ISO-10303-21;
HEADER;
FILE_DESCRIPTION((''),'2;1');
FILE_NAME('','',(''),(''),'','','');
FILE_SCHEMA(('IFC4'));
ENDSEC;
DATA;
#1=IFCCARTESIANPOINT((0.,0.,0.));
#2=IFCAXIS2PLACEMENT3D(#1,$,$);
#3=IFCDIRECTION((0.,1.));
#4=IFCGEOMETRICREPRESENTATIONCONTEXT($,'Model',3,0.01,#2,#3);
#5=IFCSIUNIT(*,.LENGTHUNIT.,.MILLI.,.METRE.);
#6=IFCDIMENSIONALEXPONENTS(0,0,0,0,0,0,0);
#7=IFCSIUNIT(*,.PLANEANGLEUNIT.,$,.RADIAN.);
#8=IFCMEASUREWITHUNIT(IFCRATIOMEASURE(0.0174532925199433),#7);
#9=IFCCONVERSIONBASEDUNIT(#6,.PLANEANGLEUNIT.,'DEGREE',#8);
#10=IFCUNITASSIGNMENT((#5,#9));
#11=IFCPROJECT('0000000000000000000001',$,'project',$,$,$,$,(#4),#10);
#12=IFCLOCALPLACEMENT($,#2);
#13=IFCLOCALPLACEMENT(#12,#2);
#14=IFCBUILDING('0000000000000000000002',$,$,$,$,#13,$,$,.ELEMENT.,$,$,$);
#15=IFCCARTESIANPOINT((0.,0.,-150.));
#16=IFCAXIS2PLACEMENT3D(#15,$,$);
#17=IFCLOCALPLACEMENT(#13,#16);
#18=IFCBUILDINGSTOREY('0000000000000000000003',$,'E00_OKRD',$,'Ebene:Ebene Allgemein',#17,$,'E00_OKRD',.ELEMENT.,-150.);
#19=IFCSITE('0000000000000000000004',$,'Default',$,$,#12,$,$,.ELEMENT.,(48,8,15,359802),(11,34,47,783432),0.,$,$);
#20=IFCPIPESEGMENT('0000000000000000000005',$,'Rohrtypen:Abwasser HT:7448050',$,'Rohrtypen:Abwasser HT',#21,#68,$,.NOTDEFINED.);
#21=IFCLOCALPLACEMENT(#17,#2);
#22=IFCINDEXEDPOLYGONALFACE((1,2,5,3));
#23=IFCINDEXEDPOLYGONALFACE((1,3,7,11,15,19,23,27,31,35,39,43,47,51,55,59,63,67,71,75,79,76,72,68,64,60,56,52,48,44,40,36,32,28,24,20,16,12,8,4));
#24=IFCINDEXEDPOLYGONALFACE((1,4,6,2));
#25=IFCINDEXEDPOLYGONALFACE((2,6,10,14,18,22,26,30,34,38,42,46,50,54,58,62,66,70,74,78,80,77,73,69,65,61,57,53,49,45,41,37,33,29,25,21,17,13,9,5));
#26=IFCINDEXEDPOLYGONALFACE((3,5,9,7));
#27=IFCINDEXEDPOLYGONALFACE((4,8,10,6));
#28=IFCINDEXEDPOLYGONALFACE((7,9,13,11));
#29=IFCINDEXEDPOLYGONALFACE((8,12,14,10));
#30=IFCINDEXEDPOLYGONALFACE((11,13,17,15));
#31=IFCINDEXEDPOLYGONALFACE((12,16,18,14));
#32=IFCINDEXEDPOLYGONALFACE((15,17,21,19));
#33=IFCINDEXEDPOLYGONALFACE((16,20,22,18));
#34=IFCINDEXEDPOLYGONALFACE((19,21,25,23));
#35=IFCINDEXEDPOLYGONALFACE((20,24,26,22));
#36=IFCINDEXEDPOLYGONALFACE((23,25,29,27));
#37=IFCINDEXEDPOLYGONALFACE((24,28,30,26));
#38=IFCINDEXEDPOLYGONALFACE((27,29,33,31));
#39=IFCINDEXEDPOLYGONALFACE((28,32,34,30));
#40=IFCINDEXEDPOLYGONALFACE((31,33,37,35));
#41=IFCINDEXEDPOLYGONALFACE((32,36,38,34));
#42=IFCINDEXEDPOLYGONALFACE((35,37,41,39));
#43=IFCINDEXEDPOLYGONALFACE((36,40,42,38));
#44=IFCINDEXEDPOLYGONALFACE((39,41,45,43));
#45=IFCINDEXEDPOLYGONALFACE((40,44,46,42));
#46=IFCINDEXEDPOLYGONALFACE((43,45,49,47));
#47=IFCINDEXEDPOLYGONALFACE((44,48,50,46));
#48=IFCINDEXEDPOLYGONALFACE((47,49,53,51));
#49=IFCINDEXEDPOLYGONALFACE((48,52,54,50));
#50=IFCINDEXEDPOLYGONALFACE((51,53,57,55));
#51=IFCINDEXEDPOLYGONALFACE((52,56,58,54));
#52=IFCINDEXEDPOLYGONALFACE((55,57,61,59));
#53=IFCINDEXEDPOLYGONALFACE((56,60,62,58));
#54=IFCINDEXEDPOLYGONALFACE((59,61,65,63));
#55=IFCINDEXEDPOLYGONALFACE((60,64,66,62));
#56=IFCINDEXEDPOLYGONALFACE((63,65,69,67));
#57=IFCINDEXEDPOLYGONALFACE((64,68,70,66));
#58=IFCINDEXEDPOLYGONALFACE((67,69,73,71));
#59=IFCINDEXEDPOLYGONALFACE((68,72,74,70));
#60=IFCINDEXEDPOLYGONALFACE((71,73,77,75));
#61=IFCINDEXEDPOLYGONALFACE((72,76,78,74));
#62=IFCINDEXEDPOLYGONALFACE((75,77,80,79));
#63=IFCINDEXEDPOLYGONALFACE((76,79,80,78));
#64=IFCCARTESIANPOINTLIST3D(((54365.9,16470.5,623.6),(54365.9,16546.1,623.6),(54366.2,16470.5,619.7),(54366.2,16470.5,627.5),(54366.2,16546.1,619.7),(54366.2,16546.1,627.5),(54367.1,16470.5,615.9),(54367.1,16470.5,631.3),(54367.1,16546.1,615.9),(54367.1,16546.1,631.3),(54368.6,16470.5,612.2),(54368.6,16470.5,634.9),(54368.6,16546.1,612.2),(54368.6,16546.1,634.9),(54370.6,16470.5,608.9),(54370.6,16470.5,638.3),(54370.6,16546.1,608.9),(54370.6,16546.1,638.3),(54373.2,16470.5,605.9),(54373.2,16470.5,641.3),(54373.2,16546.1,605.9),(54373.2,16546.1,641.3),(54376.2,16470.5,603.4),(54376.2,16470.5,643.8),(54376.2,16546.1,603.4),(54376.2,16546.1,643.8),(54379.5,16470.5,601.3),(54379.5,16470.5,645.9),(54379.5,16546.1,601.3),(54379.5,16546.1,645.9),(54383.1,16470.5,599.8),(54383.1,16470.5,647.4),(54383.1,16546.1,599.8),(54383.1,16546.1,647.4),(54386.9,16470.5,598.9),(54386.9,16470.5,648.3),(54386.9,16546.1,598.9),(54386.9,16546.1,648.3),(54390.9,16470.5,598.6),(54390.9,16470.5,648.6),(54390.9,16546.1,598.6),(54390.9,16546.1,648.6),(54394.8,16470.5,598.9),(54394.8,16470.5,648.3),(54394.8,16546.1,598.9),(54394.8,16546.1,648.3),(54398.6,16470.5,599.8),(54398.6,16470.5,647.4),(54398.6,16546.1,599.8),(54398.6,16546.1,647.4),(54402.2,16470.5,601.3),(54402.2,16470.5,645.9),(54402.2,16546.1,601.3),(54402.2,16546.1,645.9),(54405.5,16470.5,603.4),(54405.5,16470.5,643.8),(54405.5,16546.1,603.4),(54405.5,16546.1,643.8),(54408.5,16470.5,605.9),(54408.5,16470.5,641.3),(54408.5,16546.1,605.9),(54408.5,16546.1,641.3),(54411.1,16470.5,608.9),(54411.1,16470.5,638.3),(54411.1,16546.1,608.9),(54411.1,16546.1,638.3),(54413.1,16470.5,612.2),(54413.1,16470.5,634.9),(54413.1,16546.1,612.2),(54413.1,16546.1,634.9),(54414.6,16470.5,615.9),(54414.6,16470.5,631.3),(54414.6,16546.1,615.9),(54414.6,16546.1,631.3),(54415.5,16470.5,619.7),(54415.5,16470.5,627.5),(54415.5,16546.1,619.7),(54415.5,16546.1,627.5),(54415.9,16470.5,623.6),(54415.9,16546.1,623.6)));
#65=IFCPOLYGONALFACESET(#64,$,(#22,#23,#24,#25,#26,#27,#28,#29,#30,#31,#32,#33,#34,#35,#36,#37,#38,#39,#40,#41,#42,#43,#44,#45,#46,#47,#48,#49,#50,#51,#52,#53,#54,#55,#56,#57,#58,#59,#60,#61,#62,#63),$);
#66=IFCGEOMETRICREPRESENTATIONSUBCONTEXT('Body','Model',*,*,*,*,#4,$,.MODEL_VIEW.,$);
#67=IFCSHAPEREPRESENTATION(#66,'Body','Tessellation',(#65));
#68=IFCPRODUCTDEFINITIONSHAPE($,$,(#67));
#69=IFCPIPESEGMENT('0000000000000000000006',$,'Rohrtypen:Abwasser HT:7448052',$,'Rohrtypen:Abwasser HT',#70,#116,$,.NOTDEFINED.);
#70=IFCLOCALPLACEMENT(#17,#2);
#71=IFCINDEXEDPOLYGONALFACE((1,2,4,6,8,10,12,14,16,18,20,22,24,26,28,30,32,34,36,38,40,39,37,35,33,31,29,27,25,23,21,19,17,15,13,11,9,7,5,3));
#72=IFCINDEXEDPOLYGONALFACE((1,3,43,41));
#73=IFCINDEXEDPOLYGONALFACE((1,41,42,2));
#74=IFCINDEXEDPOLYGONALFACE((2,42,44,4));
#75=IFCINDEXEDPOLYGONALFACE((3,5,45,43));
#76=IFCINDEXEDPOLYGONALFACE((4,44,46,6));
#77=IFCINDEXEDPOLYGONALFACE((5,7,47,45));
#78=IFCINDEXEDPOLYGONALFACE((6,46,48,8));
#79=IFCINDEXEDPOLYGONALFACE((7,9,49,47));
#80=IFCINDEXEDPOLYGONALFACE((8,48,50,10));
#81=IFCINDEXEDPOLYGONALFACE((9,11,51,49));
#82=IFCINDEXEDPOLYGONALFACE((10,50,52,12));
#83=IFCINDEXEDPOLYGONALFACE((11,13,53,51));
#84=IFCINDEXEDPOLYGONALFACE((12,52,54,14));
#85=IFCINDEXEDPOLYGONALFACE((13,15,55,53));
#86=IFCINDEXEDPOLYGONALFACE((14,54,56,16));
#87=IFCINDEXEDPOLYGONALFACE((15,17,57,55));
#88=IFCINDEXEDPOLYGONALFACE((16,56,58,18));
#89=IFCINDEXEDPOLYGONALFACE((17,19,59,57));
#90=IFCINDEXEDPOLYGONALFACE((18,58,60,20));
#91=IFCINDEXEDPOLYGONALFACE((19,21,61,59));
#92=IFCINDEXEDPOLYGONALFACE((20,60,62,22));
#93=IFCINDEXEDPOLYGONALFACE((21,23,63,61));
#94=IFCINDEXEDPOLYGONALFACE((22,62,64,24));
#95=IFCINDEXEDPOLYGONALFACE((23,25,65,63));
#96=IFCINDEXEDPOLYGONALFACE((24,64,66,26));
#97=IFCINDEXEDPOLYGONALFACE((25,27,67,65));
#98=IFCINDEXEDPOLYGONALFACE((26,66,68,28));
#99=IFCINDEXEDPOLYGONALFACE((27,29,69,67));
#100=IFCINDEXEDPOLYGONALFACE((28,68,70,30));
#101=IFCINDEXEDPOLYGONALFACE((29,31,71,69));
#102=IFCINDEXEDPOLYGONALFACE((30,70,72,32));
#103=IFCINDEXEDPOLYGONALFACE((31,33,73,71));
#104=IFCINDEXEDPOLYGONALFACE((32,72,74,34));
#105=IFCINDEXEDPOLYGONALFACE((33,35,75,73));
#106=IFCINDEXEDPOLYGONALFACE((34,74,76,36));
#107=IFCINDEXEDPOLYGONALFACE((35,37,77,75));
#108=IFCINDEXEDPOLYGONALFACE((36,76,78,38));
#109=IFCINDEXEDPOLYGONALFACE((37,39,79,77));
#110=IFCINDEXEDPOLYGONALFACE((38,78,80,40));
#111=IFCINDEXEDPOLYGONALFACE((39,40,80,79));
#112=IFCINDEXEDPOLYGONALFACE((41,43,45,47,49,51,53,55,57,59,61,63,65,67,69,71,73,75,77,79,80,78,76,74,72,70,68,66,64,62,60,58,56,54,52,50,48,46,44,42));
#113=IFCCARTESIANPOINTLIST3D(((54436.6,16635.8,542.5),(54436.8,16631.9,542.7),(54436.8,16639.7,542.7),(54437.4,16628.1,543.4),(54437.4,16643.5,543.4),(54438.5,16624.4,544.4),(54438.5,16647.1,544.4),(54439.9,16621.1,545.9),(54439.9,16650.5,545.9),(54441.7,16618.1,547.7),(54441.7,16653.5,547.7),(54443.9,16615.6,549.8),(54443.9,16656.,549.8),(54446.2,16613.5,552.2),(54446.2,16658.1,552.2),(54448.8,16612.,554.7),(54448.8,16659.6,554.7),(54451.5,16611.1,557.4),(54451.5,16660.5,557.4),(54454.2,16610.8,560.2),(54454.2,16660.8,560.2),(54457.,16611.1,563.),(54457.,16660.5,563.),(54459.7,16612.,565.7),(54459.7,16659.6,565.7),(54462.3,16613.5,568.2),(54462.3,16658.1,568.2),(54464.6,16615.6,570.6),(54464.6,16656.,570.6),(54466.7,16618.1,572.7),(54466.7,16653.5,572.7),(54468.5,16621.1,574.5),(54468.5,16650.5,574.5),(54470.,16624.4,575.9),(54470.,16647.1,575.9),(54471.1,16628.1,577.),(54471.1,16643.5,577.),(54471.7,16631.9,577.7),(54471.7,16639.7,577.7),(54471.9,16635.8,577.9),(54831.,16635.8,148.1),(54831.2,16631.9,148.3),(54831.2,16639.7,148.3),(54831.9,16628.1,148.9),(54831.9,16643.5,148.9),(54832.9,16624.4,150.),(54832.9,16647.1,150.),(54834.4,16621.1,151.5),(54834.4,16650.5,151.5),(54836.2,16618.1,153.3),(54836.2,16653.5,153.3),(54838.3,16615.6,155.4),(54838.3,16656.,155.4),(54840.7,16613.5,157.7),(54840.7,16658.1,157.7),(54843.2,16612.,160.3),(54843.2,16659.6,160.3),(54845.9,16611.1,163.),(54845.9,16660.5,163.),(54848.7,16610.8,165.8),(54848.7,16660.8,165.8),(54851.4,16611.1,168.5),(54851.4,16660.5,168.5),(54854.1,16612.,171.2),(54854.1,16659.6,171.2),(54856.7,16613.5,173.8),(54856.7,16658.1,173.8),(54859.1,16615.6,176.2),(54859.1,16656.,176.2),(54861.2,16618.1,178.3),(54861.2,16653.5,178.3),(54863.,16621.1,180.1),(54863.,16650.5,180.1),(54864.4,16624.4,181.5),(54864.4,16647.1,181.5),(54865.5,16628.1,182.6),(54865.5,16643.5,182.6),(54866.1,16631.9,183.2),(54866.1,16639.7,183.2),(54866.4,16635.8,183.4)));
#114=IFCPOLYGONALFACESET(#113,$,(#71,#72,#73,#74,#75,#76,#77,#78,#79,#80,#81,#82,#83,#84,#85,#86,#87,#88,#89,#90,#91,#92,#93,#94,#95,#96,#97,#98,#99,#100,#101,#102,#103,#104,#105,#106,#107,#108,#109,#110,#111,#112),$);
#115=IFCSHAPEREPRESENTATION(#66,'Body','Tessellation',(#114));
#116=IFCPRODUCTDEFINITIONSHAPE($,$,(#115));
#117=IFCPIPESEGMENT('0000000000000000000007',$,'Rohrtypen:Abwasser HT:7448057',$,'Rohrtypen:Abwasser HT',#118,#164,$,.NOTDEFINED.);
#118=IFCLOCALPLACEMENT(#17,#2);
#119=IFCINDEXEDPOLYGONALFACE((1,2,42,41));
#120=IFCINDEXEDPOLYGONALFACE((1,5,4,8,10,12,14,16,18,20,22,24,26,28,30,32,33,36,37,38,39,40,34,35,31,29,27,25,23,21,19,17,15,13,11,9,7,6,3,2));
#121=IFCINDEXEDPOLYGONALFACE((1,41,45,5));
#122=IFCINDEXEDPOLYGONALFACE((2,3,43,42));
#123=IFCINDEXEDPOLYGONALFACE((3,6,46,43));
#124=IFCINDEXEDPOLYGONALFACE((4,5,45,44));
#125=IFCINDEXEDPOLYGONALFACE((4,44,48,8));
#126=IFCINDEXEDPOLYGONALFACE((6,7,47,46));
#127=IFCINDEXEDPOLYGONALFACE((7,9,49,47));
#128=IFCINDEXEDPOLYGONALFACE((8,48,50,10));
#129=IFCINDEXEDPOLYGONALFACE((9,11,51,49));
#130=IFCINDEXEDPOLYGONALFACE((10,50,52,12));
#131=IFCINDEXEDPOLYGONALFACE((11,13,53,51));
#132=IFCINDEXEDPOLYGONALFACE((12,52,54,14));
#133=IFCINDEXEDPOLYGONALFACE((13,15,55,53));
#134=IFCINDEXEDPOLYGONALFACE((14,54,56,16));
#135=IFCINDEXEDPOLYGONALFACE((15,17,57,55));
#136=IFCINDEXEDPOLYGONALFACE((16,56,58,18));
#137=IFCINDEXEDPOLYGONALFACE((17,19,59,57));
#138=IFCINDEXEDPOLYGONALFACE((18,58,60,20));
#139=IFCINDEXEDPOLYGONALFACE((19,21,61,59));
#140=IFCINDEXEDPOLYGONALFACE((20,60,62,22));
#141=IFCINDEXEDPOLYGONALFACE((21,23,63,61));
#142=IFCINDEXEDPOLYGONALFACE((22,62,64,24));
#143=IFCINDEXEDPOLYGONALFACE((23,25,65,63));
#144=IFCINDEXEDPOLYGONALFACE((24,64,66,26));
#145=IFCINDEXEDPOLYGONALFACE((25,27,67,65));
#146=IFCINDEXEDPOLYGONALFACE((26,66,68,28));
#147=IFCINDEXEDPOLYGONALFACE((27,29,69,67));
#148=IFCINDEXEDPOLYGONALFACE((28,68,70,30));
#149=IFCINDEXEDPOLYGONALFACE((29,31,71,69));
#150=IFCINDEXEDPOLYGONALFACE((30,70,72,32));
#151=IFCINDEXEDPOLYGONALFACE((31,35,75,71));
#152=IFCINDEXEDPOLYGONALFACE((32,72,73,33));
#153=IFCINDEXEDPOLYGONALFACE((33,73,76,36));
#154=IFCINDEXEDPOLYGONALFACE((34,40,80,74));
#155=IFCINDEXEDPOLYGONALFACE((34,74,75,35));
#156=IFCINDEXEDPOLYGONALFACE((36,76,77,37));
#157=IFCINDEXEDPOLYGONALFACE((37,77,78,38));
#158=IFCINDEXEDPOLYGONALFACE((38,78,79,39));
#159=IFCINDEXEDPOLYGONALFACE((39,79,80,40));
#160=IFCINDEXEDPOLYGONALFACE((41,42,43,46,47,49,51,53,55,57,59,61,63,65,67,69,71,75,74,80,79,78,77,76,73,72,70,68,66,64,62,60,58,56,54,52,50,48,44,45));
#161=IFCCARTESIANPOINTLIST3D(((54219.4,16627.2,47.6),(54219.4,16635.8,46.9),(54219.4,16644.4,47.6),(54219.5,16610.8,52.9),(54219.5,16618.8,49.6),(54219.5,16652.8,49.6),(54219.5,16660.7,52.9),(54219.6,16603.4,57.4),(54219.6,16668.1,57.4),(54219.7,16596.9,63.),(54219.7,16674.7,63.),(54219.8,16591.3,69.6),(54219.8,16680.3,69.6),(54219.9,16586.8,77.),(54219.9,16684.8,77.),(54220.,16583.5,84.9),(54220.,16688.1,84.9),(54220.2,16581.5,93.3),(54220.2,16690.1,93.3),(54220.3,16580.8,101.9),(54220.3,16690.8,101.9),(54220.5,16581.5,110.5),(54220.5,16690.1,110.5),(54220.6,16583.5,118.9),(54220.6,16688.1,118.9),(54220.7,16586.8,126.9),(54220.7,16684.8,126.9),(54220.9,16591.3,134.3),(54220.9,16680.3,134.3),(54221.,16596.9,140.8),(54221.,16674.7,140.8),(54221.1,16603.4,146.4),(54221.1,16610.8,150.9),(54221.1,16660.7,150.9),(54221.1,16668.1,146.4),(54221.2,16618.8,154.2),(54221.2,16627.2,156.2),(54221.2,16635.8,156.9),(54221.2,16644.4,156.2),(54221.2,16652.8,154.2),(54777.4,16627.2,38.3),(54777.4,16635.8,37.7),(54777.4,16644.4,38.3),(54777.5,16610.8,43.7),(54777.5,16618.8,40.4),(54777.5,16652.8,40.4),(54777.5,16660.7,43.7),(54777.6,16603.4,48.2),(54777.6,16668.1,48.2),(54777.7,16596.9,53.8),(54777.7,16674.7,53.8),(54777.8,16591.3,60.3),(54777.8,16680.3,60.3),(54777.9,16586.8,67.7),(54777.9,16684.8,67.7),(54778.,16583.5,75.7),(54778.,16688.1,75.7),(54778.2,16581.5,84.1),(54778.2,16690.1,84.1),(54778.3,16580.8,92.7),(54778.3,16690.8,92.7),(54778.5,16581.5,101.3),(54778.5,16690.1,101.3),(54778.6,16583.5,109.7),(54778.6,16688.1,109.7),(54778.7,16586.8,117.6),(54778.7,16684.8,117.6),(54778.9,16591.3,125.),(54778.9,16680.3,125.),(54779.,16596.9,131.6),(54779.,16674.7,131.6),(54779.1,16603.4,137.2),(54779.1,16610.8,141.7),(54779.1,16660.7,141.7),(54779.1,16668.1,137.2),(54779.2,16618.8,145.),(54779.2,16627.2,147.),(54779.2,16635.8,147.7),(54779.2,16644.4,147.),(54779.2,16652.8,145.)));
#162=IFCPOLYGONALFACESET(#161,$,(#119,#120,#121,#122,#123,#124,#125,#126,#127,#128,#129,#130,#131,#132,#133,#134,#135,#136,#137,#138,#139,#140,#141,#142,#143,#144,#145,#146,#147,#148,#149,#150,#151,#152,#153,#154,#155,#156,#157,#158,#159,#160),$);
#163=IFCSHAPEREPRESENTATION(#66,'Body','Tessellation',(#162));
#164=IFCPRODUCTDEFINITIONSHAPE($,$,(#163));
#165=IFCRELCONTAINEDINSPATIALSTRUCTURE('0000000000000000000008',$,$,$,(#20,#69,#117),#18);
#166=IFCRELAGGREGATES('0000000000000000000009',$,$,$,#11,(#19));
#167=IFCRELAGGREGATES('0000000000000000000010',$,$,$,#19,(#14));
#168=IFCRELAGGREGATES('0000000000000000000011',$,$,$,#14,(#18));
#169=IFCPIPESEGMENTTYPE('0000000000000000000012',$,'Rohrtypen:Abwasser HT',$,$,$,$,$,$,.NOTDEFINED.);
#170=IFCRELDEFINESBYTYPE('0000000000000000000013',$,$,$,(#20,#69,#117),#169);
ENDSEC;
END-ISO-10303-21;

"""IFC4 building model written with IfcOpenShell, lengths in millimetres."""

from ifc_helpers import new_model, entity, si_unit, converted_unit, direction, frame, origin, place, context, subcontext, project, spatial, indexed_curve, outline, extrude, type_object, element, save


model = new_model("IFC4")

# Units and contexts
model_context = context("Model", 3, precision=0.01, world=origin(), true_north=direction((0.0, 1.0)))
body_context = subcontext(model_context, "Body", "Model", "MODEL_VIEW")
ifc_project = project(units=[si_unit("LENGTHUNIT", "METRE", prefix="MILLI"), converted_unit("PLANEANGLEUNIT", "DEGREE", entity("IfcRatioMeasure", 0.0174532925199433), si_unit("PLANEANGLEUNIT", "RADIAN"), dimensions=[0, 0, 0, 0, 0, 0, 0])], contexts=[model_context])

# Site, building, storey
site_placement = place(None, origin())
site = spatial("IfcSite", under=ifc_project, at=site_placement, Name="Default", CompositionType="ELEMENT", RefLatitude=(48, 8, 15, 359802), RefLongitude=(11, 34, 47, 783432), RefElevation=0.0)
building_placement = place(site_placement, origin())
building = spatial("IfcBuilding", under=site, at=building_placement, CompositionType="ELEMENT")
storey_placement = place(building_placement, frame((0.0, 0.0, -150.0)))
storey = spatial("IfcBuildingStorey", under=building, at=storey_placement, Name="E00_OKRD", ObjectType="Ebene:Ebene Allgemein", LongName="E00_OKRD", CompositionType="ELEMENT", Elevation=-150.0)

# Pipe segments
pipe_segment_type_1 = type_object("IfcPipeSegmentType", Name="Rohrtypen:Abwasser HT", PredefinedType="NOTDEFINED")
pipe_segment_1_placement = place(storey_placement, origin())
element("IfcPipeSegment", 1, at=pipe_segment_1_placement, inside=storey, type_object=pipe_segment_type_1, Name="Rohrtypen:Abwasser HT:7448050", ObjectType="Rohrtypen:Abwasser HT", PredefinedType="NOTDEFINED", context=body_context, shape_type="SweptSolid", body=[
    extrude(outline(indexed_curve([(25.0, 0.0), (24.7, 3.9), (23.8, 7.7), (22.3, 11.3), (20.2, 14.7), (17.7, 17.7), (14.7, 20.2), (11.3, 22.3), (7.7, 23.8), (3.9, 24.7), (0.0, 25.0), (-3.9, 24.7), (-7.7, 23.8), (-11.3, 22.3), (-14.7, 20.2), (-17.7, 17.7), (-20.2, 14.7), (-22.3, 11.3), (-23.8, 7.7), (-24.7, 3.9), (-25.0, 0.0), (-24.7, -3.9), (-23.8, -7.7), (-22.3, -11.3), (-20.2, -14.7), (-17.7, -17.7), (-14.7, -20.2), (-11.3, -22.3), (-7.7, -23.8), (-3.9, -24.7), (0.0, -25.0), (3.9, -24.7), (7.7, -23.8), (11.3, -22.3), (14.7, -20.2), (17.7, -17.7), (20.2, -14.7), (22.3, -11.3), (23.8, -7.7), (24.7, -3.9), (25.0, 0.0)], self_intersect=False)), frame((54390.9, 16470.5, 623.6), z_axis=(0.0, 1.0, 0.0), x_axis=(1.0, 0.0, 0.0)), (0.0, 0.0, 1.0), 75.6),
])
pipe_segment_2_placement = place(storey_placement, origin())
element("IfcPipeSegment", 2, at=pipe_segment_2_placement, inside=storey, type_object=pipe_segment_type_1, Name="Rohrtypen:Abwasser HT:7448052", ObjectType="Rohrtypen:Abwasser HT", PredefinedType="NOTDEFINED", context=body_context, shape_type="SweptSolid", body=[
    extrude(outline(indexed_curve([(25.0, 0.0), (24.7, 3.9), (23.8, 7.7), (22.3, 11.3), (20.2, 14.7), (17.7, 17.7), (14.7, 20.2), (11.3, 22.3), (7.7, 23.8), (3.9, 24.7), (0.0, 25.0), (-3.9, 24.7), (-7.7, 23.8), (-11.3, 22.3), (-14.7, 20.2), (-17.7, 17.7), (-20.2, 14.7), (-22.3, 11.3), (-23.8, 7.7), (-24.7, 3.9), (-25.0, 0.0), (-24.7, -3.9), (-23.8, -7.7), (-22.3, -11.3), (-20.2, -14.7), (-17.7, -17.7), (-14.7, -20.2), (-11.3, -22.3), (-7.7, -23.8), (-3.9, -24.7), (0.0, -25.0), (3.9, -24.7), (7.7, -23.8), (11.3, -22.3), (14.7, -20.2), (17.7, -17.7), (20.2, -14.7), (22.3, -11.3), (23.8, -7.7), (24.7, -3.9), (25.0, 0.0)], self_intersect=False)), frame((54454.2, 16635.8, 560.2), z_axis=(0.707107, 0.0, -0.707107), x_axis=(0.0, -1.0, 0.0)), (0.0, 0.0, 1.0), 557.8),
])
pipe_segment_3_placement = place(storey_placement, origin())
element("IfcPipeSegment", 3, at=pipe_segment_3_placement, inside=storey, type_object=pipe_segment_type_1, Name="Rohrtypen:Abwasser HT:7448057", ObjectType="Rohrtypen:Abwasser HT", PredefinedType="NOTDEFINED", context=body_context, shape_type="SweptSolid", body=[
    extrude(outline(indexed_curve([(55.0, 0.0), (54.3, 8.6), (52.3, 17.0), (49.0, 25.0), (44.5, 32.3), (38.9, 38.9), (32.3, 44.5), (25.0, 49.0), (17.0, 52.3), (8.6, 54.3), (0.0, 55.0), (-8.6, 54.3), (-17.0, 52.3), (-25.0, 49.0), (-32.3, 44.5), (-38.9, 38.9), (-44.5, 32.3), (-49.0, 25.0), (-52.3, 17.0), (-54.3, 8.6), (-55.0, 0.0), (-54.3, -8.6), (-52.3, -17.0), (-49.0, -25.0), (-44.5, -32.3), (-38.9, -38.9), (-32.3, -44.5), (-25.0, -49.0), (-17.0, -52.3), (-8.6, -54.3), (0.0, -55.0), (8.6, -54.3), (17.0, -52.3), (25.0, -49.0), (32.3, -44.5), (38.9, -38.9), (44.5, -32.3), (49.0, -25.0), (52.3, -17.0), (54.3, -8.6), (55.0, 0.0)], self_intersect=False)), frame((54778.3, 16635.8, 92.7), z_axis=(-0.999862, 0.0, 0.016604), x_axis=(0.0, -1.0, 0.0)), (0.0, 0.0, 1.0), 558.1),
])

save(model, "model.ifc")
